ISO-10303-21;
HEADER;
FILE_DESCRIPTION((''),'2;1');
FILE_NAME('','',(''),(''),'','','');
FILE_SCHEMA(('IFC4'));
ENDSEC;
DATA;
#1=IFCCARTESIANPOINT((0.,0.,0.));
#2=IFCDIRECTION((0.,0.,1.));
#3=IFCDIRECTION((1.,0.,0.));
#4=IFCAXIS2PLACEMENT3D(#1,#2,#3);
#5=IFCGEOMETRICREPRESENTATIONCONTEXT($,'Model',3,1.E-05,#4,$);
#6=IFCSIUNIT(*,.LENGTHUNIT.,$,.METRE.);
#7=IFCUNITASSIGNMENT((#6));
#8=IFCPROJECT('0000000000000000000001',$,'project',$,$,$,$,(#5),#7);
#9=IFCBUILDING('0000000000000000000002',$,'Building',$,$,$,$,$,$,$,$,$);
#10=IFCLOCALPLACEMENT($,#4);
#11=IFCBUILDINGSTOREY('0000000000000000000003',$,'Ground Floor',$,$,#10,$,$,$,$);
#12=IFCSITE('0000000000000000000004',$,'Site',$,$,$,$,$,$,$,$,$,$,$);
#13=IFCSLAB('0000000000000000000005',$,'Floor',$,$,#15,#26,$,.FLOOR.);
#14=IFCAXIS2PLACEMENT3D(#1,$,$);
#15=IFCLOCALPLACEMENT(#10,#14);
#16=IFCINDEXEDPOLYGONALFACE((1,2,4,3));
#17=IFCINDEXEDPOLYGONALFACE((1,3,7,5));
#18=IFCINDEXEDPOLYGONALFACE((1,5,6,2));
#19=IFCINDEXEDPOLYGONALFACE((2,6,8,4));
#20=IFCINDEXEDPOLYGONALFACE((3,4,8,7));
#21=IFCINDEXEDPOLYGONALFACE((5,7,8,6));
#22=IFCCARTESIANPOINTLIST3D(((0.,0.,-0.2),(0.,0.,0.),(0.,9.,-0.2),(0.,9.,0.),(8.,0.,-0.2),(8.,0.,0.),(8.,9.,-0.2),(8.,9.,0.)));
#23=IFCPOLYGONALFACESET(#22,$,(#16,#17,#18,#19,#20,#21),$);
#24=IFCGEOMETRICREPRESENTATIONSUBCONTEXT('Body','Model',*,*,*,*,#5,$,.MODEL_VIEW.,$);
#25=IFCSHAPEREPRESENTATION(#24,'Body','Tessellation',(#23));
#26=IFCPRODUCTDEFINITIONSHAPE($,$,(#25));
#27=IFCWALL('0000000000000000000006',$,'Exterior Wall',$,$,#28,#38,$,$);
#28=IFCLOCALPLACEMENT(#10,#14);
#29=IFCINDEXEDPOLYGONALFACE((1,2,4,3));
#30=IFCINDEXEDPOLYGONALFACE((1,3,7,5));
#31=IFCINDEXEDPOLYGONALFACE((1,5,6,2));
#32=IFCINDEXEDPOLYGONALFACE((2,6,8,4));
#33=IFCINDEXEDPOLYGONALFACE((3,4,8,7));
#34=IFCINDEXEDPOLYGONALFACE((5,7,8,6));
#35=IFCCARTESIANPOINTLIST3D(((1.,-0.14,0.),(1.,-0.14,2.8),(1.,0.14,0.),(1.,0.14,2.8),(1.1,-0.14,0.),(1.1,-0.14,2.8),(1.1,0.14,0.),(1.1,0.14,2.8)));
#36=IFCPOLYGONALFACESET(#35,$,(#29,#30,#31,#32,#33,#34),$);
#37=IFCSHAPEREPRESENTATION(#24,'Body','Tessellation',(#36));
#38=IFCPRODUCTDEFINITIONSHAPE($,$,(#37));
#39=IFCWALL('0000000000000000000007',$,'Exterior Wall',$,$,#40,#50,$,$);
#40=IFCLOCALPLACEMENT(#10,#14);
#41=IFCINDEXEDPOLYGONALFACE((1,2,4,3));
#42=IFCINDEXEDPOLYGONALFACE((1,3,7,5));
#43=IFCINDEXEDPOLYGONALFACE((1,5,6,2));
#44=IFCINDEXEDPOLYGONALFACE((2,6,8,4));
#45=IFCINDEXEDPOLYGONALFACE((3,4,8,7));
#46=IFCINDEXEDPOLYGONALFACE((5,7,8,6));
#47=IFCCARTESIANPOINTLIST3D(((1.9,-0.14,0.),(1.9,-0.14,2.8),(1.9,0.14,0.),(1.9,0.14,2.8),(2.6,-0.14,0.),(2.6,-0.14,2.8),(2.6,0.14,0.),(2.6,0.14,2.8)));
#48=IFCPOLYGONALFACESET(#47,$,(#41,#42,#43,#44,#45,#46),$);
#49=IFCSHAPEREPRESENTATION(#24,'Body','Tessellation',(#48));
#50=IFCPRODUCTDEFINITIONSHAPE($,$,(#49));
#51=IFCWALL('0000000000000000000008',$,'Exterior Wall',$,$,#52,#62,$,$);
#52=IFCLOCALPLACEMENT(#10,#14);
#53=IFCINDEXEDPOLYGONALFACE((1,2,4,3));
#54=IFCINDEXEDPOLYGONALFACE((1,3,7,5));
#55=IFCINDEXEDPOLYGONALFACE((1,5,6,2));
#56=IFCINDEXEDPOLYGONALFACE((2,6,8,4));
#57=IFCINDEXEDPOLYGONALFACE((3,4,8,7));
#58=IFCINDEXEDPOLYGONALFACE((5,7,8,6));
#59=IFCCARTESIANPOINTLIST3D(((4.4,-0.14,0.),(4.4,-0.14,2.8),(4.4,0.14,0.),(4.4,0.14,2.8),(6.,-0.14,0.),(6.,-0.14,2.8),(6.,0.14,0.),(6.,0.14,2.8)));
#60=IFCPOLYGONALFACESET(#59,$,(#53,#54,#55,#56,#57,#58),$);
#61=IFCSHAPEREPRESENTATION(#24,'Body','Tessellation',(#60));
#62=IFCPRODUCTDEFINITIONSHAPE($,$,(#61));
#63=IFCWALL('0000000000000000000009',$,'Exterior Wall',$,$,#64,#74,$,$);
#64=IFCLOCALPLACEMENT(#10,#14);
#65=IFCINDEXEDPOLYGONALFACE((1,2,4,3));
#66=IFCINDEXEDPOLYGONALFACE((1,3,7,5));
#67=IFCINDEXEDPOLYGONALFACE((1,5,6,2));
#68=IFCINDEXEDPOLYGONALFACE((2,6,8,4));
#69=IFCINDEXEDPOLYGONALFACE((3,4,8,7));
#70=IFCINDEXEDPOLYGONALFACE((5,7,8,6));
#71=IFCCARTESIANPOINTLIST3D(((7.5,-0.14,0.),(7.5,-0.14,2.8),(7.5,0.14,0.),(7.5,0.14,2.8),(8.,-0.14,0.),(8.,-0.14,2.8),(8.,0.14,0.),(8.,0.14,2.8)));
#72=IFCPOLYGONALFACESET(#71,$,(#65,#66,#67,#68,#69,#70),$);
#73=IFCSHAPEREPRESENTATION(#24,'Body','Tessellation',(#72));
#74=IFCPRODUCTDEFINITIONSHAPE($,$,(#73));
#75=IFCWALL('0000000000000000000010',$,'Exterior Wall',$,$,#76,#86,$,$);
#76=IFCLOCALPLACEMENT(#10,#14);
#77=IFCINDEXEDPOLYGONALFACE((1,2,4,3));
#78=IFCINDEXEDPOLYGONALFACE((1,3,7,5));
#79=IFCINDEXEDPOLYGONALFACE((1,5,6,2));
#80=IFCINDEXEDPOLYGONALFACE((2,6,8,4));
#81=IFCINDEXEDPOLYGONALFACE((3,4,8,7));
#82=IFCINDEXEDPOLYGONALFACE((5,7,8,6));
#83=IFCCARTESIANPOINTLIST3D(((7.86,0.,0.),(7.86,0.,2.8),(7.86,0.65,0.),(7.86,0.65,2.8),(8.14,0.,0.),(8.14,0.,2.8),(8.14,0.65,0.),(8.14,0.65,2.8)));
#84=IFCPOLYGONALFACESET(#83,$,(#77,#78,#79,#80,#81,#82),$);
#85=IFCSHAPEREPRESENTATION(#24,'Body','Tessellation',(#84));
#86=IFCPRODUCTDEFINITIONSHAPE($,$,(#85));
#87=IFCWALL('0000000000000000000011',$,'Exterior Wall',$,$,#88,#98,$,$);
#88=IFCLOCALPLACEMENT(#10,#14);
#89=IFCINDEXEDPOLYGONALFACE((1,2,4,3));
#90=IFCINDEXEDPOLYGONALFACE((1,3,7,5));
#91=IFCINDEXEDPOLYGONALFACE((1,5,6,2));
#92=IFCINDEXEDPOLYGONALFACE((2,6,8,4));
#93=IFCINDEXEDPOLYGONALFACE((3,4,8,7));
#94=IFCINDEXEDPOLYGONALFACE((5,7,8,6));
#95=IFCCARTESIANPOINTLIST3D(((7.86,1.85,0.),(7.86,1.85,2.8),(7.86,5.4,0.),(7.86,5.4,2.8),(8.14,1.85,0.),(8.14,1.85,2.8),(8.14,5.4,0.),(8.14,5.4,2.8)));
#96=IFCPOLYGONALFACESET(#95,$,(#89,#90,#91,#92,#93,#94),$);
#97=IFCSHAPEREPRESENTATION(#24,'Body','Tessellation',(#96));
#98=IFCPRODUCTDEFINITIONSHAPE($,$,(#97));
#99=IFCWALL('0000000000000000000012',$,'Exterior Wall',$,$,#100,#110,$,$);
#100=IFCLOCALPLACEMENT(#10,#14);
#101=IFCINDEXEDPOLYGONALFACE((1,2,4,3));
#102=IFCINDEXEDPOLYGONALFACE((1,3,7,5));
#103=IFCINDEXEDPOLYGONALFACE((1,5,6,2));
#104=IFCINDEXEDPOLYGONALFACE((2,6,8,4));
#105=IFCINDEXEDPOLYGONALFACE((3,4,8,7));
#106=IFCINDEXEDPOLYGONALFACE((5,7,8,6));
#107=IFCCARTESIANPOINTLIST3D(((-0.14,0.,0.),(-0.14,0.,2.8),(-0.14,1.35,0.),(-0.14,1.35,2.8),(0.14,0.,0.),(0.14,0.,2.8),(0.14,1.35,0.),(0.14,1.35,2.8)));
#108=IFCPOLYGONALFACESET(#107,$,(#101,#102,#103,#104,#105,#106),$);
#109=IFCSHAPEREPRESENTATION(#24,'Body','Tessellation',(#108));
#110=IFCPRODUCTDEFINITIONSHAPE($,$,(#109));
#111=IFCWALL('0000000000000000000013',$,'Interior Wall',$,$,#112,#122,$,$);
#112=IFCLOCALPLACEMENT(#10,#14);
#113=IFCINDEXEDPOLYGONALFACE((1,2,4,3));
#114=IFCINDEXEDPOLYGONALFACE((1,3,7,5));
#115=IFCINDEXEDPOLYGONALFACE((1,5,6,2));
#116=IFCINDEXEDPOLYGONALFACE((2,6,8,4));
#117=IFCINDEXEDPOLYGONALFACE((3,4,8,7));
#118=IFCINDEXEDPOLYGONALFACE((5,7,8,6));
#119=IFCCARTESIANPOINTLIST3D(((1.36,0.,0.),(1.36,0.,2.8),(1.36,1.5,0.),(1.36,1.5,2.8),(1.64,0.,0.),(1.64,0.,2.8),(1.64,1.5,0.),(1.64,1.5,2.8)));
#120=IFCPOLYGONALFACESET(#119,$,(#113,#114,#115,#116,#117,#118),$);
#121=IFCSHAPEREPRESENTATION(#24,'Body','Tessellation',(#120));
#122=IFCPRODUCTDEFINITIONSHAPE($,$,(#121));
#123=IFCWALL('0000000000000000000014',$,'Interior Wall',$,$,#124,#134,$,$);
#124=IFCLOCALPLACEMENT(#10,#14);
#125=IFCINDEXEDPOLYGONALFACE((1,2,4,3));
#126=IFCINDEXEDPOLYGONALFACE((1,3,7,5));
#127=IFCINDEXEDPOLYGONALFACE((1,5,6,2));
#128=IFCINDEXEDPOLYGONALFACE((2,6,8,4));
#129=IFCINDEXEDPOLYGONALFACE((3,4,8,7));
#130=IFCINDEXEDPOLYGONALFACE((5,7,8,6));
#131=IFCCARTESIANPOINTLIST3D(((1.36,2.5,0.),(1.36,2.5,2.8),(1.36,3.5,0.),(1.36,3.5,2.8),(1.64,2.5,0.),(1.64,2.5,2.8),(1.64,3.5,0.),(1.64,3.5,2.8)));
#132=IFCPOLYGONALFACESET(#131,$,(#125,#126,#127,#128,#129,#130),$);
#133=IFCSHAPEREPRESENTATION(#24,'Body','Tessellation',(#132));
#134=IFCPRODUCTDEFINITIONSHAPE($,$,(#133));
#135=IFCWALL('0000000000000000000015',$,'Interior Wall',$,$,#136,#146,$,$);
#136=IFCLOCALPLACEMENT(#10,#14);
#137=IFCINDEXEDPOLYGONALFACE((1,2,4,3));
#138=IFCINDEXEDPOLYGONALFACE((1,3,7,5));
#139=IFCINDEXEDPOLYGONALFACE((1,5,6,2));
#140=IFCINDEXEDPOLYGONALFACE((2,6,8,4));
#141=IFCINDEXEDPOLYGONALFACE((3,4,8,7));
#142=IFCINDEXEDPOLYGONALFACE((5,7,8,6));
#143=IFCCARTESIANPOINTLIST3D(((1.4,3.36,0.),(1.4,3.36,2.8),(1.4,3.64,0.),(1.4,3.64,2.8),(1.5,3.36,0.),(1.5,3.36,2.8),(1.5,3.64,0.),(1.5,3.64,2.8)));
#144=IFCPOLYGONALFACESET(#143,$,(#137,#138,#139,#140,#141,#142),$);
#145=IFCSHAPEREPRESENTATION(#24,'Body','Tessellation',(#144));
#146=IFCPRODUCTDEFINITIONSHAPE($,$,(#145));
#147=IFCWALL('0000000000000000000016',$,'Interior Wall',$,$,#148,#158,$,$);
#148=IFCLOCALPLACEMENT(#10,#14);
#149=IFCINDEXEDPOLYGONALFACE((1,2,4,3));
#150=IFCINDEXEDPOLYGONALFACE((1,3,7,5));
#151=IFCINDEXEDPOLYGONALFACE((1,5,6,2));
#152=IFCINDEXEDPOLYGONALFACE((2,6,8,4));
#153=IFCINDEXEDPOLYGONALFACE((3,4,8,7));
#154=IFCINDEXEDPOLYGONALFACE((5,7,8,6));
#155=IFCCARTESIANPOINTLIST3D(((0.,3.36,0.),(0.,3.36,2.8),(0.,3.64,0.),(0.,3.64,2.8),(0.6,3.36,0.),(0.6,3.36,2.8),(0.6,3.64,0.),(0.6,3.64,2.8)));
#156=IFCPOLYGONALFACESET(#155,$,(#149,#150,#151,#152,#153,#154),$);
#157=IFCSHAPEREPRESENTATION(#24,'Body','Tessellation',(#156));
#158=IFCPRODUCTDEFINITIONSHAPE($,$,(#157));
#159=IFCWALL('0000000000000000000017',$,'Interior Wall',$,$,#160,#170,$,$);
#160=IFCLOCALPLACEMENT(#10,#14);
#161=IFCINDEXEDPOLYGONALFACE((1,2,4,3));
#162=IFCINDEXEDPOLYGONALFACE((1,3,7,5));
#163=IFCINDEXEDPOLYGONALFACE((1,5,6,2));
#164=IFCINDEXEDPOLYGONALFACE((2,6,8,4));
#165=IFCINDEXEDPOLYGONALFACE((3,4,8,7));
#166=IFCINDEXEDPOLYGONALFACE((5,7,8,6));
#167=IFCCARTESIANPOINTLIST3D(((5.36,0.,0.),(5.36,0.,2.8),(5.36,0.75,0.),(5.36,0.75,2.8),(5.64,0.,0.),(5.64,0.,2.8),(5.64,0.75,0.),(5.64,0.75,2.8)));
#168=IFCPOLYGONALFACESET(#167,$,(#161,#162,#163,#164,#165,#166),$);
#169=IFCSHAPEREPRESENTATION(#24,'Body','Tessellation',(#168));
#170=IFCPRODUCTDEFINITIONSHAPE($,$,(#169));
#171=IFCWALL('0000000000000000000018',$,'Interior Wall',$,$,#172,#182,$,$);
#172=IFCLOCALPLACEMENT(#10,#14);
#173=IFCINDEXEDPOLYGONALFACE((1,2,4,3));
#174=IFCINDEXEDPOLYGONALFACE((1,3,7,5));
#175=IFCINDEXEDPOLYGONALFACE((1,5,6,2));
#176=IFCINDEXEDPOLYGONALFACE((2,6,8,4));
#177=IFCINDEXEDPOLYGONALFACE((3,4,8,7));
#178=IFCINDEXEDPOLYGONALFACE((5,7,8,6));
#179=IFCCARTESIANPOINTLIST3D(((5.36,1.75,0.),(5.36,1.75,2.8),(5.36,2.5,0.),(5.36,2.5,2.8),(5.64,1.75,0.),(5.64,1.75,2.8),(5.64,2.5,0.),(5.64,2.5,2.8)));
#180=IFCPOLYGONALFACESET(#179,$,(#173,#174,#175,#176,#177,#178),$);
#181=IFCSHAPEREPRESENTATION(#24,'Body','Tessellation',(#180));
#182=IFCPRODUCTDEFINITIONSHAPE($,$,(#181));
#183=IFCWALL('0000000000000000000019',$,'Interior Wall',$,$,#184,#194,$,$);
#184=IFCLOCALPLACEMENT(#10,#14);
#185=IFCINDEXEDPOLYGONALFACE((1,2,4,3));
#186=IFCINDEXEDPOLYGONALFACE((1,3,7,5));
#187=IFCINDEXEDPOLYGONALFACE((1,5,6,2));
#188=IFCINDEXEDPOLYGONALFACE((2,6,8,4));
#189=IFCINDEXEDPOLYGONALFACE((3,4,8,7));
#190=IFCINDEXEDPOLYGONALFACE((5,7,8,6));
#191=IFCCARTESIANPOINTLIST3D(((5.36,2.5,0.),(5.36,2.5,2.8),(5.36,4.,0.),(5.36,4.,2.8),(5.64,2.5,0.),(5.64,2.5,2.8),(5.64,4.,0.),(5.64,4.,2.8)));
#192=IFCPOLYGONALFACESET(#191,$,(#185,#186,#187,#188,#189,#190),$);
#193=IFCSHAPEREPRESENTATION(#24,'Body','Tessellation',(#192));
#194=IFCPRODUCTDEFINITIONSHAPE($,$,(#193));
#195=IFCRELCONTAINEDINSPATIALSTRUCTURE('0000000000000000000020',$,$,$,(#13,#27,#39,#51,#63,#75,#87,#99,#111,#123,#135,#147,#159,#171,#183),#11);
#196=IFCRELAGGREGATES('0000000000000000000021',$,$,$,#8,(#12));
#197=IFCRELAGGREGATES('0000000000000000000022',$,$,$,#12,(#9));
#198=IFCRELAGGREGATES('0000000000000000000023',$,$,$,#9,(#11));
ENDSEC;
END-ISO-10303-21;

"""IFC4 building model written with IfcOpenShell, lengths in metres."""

from ifc_helpers import new_model, si_unit, frame, origin_with_axes, place, context, subcontext, project, spatial, indexed_curve, outline, extrude, element, save


model = new_model("IFC4")

# Units and contexts
model_context = context("Model", 3, precision=1e-05, world=origin_with_axes())
body_context = subcontext(model_context, "Body", "Model", "MODEL_VIEW")
ifc_project = project(units=[si_unit("LENGTHUNIT", "METRE")], contexts=[model_context])

# Site, building, storey
site = spatial("IfcSite", under=ifc_project, Name="Site")
building = spatial("IfcBuilding", under=site, Name="Building")
storey_placement = place(None, origin_with_axes())
storey = spatial("IfcBuildingStorey", under=building, at=storey_placement, Name="Ground Floor")

# Slab
slab_placement = place(storey_placement, frame((0.0, 0.0, -0.2), z_axis=(0.0, 0.0, 1.0), x_axis=(1.0, 0.0, 0.0)))
element("IfcSlab", 1, at=slab_placement, inside=storey, Name="Floor", PredefinedType="FLOOR", context=body_context, shape_type="SweptSolid", body=[
    extrude(outline(indexed_curve([(0.0, 0.0), (8.0, 0.0), (8.0, 9.0), (0.0, 9.0)])), None, (0.0, 0.0, 1.0), 0.2),
])

# Walls
wall_1_placement = place(storey_placement, frame((1.0, 0.0, 0.0), z_axis=(0.0, 0.0, 1.0), x_axis=(1.0, 0.0, 0.0)))
element("IfcWall", 2, at=wall_1_placement, inside=storey, Name="Exterior Wall", context=body_context, shape_type="SweptSolid", body=[
    extrude(outline(indexed_curve([(0.0, 0.0), (0.0, 0.28), (0.1, 0.28), (0.1, 0.0), (0.0, 0.0)], self_intersect=False)), frame((0.0, -0.14, 0.0), z_axis=(0.0, 0.0, 1.0), x_axis=(1.0, 0.0, 0.0)), (0.0, 0.0, 1.0), 2.8),
])
wall_2_placement = place(storey_placement, frame((1.9, 0.0, 0.0), z_axis=(0.0, 0.0, 1.0), x_axis=(1.0, 0.0, 0.0)))
element("IfcWall", 3, at=wall_2_placement, inside=storey, Name="Exterior Wall", context=body_context, shape_type="SweptSolid", body=[
    extrude(outline(indexed_curve([(0.0, 0.0), (0.0, 0.28), (0.7, 0.28), (0.7, 0.0), (0.0, 0.0)], self_intersect=False)), frame((0.0, -0.14, 0.0), z_axis=(0.0, 0.0, 1.0), x_axis=(1.0, 0.0, 0.0)), (0.0, 0.0, 1.0), 2.8),
])
wall_3_placement = place(storey_placement, frame((4.4, 0.0, 0.0), z_axis=(0.0, 0.0, 1.0), x_axis=(1.0, 0.0, 0.0)))
element("IfcWall", 4, at=wall_3_placement, inside=storey, Name="Exterior Wall", context=body_context, shape_type="SweptSolid", body=[
    extrude(outline(indexed_curve([(0.0, 0.0), (0.0, 0.28), (1.6, 0.28), (1.6, 0.0), (0.0, 0.0)], self_intersect=False)), frame((0.0, -0.14, 0.0), z_axis=(0.0, 0.0, 1.0), x_axis=(1.0, 0.0, 0.0)), (0.0, 0.0, 1.0), 2.8),
])
wall_4_placement = place(storey_placement, frame((7.5, 0.0, 0.0), z_axis=(0.0, 0.0, 1.0), x_axis=(1.0, 0.0, 0.0)))
element("IfcWall", 5, at=wall_4_placement, inside=storey, Name="Exterior Wall", context=body_context, shape_type="SweptSolid", body=[
    extrude(outline(indexed_curve([(0.0, 0.0), (0.0, 0.28), (0.5, 0.28), (0.5, 0.0), (0.0, 0.0)], self_intersect=False)), frame((0.0, -0.14, 0.0), z_axis=(0.0, 0.0, 1.0), x_axis=(1.0, 0.0, 0.0)), (0.0, 0.0, 1.0), 2.8),
])
wall_5_placement = place(storey_placement, frame((8.0, 0.0, 0.0), z_axis=(0.0, 0.0, 1.0), x_axis=(0.0, 1.0, 0.0)))
element("IfcWall", 6, at=wall_5_placement, inside=storey, Name="Exterior Wall", context=body_context, shape_type="SweptSolid", body=[
    extrude(outline(indexed_curve([(0.0, 0.0), (0.0, 0.28), (0.65, 0.28), (0.65, 0.0), (0.0, 0.0)], self_intersect=False)), frame((0.0, -0.14, 0.0), z_axis=(0.0, 0.0, 1.0), x_axis=(1.0, 0.0, 0.0)), (0.0, 0.0, 1.0), 2.8),
])
wall_6_placement = place(storey_placement, frame((8.0, 1.85, 0.0), z_axis=(0.0, 0.0, 1.0), x_axis=(0.0, 1.0, 0.0)))
element("IfcWall", 7, at=wall_6_placement, inside=storey, Name="Exterior Wall", context=body_context, shape_type="SweptSolid", body=[
    extrude(outline(indexed_curve([(0.0, 0.0), (0.0, 0.28), (3.55, 0.28), (3.55, 0.0), (0.0, 0.0)], self_intersect=False)), frame((0.0, -0.14, 0.0), z_axis=(0.0, 0.0, 1.0), x_axis=(1.0, 0.0, 0.0)), (0.0, 0.0, 1.0), 2.8),
])
wall_7_placement = place(storey_placement, frame((0.0, 1.35, 0.0), z_axis=(0.0, 0.0, 1.0), x_axis=(0.0, -1.0, 0.0)))
element("IfcWall", 8, at=wall_7_placement, inside=storey, Name="Exterior Wall", context=body_context, shape_type="SweptSolid", body=[
    extrude(outline(indexed_curve([(0.0, 0.0), (0.0, 0.28), (1.35, 0.28), (1.35, 0.0), (0.0, 0.0)], self_intersect=False)), frame((0.0, -0.14, 0.0), z_axis=(0.0, 0.0, 1.0), x_axis=(1.0, 0.0, 0.0)), (0.0, 0.0, 1.0), 2.8),
])
wall_8_placement = place(storey_placement, frame((1.5, 0.0, 0.0), z_axis=(0.0, 0.0, 1.0), x_axis=(0.0, 1.0, 0.0)))
element("IfcWall", 9, at=wall_8_placement, inside=storey, Name="Interior Wall", context=body_context, shape_type="SweptSolid", body=[
    extrude(outline(indexed_curve([(0.0, 0.0), (0.0, 0.28), (1.5, 0.28), (1.5, 0.0), (0.0, 0.0)], self_intersect=False)), frame((0.0, -0.14, 0.0), z_axis=(0.0, 0.0, 1.0), x_axis=(1.0, 0.0, 0.0)), (0.0, 0.0, 1.0), 2.8),
])
wall_9_placement = place(storey_placement, frame((1.5, 2.5, 0.0), z_axis=(0.0, 0.0, 1.0), x_axis=(0.0, 1.0, 0.0)))
element("IfcWall", 10, at=wall_9_placement, inside=storey, Name="Interior Wall", context=body_context, shape_type="SweptSolid", body=[
    extrude(outline(indexed_curve([(0.0, 0.0), (0.0, 0.28), (1.0, 0.28), (1.0, 0.0), (0.0, 0.0)], self_intersect=False)), frame((0.0, -0.14, 0.0), z_axis=(0.0, 0.0, 1.0), x_axis=(1.0, 0.0, 0.0)), (0.0, 0.0, 1.0), 2.8),
])
wall_10_placement = place(storey_placement, frame((1.5, 3.5, 0.0), z_axis=(0.0, 0.0, 1.0), x_axis=(-1.0, 0.0, 0.0)))
element("IfcWall", 11, at=wall_10_placement, inside=storey, Name="Interior Wall", context=body_context, shape_type="SweptSolid", body=[
    extrude(outline(indexed_curve([(0.0, 0.0), (0.0, 0.28), (0.1, 0.28), (0.1, 0.0), (0.0, 0.0)], self_intersect=False)), frame((0.0, -0.14, 0.0), z_axis=(0.0, 0.0, 1.0), x_axis=(1.0, 0.0, 0.0)), (0.0, 0.0, 1.0), 2.8),
])
wall_11_placement = place(storey_placement, frame((0.6, 3.5, 0.0), z_axis=(0.0, 0.0, 1.0), x_axis=(-1.0, 0.0, 0.0)))
element("IfcWall", 12, at=wall_11_placement, inside=storey, Name="Interior Wall", context=body_context, shape_type="SweptSolid", body=[
    extrude(outline(indexed_curve([(0.0, 0.0), (0.0, 0.28), (0.6, 0.28), (0.6, 0.0), (0.0, 0.0)], self_intersect=False)), frame((0.0, -0.14, 0.0), z_axis=(0.0, 0.0, 1.0), x_axis=(1.0, 0.0, 0.0)), (0.0, 0.0, 1.0), 2.8),
])
for number, where, z_axis, x_axis, name in (
    (13, (5.5, 0.0, 0.0), (0.0, 0.0, 1.0), (0.0, 1.0, 0.0), "Interior Wall"),
    (14, (5.5, 1.75, 0.0), (0.0, 0.0, 1.0), (0.0, 1.0, 0.0), "Interior Wall"),
):
    element("IfcWall", number, at=place(storey_placement, frame(where, z_axis=z_axis, x_axis=x_axis)), inside=storey, Name=name, context=body_context, shape_type="SweptSolid", body=[
        extrude(outline(indexed_curve([(0.0, 0.0), (0.0, 0.28), (0.75, 0.28), (0.75, 0.0), (0.0, 0.0)], self_intersect=False)), frame((0.0, -0.14, 0.0), z_axis=(0.0, 0.0, 1.0), x_axis=(1.0, 0.0, 0.0)), (0.0, 0.0, 1.0), 2.8),
    ])
wall_12_placement = place(storey_placement, frame((5.5, 2.5, 0.0), z_axis=(0.0, 0.0, 1.0), x_axis=(0.0, 1.0, 0.0)))
element("IfcWall", 15, at=wall_12_placement, inside=storey, Name="Interior Wall", context=body_context, shape_type="SweptSolid", body=[
    extrude(outline(indexed_curve([(0.0, 0.0), (0.0, 0.28), (1.5, 0.28), (1.5, 0.0), (0.0, 0.0)], self_intersect=False)), frame((0.0, -0.14, 0.0), z_axis=(0.0, 0.0, 1.0), x_axis=(1.0, 0.0, 0.0)), (0.0, 0.0, 1.0), 2.8),
])

save(model, "model.ifc")
